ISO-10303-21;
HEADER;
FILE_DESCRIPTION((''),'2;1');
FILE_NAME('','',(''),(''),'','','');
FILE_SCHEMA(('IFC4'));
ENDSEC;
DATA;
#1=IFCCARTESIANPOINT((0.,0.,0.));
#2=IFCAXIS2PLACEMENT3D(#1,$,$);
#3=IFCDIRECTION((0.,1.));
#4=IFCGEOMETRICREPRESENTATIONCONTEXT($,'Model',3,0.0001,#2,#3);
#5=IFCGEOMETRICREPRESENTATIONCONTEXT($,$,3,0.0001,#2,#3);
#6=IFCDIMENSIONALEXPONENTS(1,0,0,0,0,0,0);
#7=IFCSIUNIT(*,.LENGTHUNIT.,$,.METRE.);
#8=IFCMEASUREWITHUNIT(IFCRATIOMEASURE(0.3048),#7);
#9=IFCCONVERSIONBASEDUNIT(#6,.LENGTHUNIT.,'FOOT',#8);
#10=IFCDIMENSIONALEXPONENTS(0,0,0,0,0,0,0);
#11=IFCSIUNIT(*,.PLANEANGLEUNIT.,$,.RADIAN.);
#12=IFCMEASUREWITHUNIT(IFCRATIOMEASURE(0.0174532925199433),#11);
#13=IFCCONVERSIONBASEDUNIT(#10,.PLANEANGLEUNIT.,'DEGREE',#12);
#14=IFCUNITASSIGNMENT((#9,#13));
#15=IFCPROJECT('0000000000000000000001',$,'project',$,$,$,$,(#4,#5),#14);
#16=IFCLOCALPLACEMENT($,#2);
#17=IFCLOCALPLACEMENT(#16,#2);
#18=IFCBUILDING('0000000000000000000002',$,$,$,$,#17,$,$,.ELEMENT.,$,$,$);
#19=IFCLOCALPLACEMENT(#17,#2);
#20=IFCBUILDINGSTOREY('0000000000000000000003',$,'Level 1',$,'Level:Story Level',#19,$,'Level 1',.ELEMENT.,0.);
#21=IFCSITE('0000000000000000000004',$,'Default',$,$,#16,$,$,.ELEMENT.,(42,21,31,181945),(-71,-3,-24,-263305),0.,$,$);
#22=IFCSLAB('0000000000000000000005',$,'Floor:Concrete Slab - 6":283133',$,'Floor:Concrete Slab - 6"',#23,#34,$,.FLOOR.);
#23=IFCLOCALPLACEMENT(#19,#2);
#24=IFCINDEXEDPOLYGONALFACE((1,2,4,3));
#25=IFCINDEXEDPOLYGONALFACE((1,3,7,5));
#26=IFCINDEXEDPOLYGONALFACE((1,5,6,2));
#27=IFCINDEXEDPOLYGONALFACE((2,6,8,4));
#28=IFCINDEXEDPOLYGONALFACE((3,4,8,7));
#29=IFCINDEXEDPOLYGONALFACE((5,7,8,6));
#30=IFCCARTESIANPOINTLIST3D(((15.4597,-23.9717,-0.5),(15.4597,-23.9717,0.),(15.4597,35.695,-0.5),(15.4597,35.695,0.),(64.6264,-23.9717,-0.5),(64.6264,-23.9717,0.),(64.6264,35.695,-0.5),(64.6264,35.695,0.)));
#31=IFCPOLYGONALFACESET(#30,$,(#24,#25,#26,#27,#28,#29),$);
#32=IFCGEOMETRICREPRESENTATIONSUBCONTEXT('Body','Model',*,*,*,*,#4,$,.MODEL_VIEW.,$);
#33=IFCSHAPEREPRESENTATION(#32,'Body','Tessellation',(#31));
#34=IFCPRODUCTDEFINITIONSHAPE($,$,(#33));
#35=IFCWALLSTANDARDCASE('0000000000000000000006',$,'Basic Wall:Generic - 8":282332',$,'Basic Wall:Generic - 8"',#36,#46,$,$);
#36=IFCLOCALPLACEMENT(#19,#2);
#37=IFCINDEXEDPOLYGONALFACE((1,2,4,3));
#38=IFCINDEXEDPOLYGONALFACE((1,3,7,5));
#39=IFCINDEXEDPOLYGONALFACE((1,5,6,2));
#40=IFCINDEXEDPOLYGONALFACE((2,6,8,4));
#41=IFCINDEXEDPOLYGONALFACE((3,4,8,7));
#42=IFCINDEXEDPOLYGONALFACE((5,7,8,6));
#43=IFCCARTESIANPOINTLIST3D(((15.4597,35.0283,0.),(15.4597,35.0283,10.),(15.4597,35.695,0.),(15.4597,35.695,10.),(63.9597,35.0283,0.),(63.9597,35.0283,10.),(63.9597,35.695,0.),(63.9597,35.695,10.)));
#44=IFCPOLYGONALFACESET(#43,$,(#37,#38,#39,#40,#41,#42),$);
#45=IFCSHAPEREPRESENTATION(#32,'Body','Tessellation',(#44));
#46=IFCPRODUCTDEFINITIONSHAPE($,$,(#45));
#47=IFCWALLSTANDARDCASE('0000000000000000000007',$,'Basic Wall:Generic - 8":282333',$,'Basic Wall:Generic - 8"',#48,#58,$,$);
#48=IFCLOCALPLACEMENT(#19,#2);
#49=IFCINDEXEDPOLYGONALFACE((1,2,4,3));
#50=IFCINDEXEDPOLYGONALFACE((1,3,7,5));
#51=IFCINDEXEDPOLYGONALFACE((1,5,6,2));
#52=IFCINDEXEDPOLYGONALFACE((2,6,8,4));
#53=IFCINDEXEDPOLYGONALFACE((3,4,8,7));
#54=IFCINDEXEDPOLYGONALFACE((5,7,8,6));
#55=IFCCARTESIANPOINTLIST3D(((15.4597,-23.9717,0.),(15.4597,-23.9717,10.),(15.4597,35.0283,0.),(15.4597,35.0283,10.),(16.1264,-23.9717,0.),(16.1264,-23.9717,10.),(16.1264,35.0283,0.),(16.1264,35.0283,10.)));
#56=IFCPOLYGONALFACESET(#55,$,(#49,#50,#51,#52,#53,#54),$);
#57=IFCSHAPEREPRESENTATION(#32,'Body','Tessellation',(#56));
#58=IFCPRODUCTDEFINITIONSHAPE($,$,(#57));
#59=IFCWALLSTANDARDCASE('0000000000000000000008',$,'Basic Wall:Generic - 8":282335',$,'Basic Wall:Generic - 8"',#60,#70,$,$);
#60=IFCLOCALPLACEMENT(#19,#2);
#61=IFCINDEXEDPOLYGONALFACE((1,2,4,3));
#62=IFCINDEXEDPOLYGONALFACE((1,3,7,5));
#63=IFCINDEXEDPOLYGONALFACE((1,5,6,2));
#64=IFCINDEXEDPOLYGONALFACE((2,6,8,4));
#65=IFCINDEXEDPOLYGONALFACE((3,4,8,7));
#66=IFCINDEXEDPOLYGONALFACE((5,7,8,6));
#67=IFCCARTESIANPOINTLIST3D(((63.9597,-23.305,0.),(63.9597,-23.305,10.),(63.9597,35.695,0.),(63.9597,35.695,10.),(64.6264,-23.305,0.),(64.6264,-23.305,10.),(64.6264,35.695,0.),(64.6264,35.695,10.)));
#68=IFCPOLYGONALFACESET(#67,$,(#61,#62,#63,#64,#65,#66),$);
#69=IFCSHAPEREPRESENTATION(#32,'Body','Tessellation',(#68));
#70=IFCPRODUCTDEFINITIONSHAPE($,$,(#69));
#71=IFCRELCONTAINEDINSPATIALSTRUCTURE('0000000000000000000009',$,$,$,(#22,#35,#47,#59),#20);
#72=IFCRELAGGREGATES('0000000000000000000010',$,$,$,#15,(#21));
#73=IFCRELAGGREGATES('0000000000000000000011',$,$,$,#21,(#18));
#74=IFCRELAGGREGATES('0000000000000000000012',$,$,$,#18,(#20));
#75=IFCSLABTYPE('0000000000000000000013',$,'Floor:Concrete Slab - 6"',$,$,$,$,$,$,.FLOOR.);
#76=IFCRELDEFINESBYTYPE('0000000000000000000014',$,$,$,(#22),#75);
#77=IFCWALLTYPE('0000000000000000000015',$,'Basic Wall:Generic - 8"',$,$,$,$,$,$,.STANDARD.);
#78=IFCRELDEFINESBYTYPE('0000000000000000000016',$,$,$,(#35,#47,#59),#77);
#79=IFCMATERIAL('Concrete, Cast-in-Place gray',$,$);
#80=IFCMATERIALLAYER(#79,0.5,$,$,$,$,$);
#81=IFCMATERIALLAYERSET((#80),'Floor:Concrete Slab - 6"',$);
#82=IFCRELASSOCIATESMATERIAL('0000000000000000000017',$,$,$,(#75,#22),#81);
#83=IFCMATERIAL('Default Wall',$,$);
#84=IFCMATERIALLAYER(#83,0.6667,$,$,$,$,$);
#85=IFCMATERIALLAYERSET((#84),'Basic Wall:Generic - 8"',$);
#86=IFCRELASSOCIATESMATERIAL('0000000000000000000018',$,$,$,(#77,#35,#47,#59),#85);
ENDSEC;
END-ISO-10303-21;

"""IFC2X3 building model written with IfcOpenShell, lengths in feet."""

from ifc_helpers import new_model, entity, si_unit, converted_unit, direction, frame, frame_2d, origin, place, context, subcontext, project, spatial, rectangle, extrude, material, layer, layer_set, layer_usage, type_object, element, save


model = new_model("IFC2X3")

# Units and contexts
model_context = context("Model", 3, precision=0.0001, world=origin(), true_north=direction((0.0, 1.0)))
context_of_model = context(None, 3, precision=0.0001, world=origin(), true_north=direction((0.0, 1.0)))
body_context = subcontext(model_context, "Body", "Model", "MODEL_VIEW")
ifc_project = project(units=[converted_unit("LENGTHUNIT", "FOOT", entity("IfcRatioMeasure", 0.3048), si_unit("LENGTHUNIT", "METRE"), dimensions=[1, 0, 0, 0, 0, 0, 0]), converted_unit("PLANEANGLEUNIT", "DEGREE", entity("IfcRatioMeasure", 0.0174532925199433), si_unit("PLANEANGLEUNIT", "RADIAN"), dimensions=[0, 0, 0, 0, 0, 0, 0])], contexts=[model_context, context_of_model])

# Site, building, storey
site_placement = place(None, origin())
site = spatial("IfcSite", under=ifc_project, at=site_placement, Name="Default", CompositionType="ELEMENT", RefLatitude=(42, 21, 31, 181945), RefLongitude=(-71, -3, -24, -263305), RefElevation=0.0)
building_placement = place(site_placement, origin())
building = spatial("IfcBuilding", under=site, at=building_placement, CompositionType="ELEMENT")
storey_placement = place(building_placement, origin())
storey = spatial("IfcBuildingStorey", under=building, at=storey_placement, Name="Level 1", ObjectType="Level:Story Level", LongName="Level 1", CompositionType="ELEMENT", Elevation=0.0)

# Slab
ifc_material_1 = material(Name="Concrete, Cast-in-Place gray")
ifc_layer_1 = layer(ifc_material_1, 0.5)
ifc_layer_set_1 = layer_set([ifc_layer_1], Name="Floor:Concrete Slab - 6\"")
ifc_layer_usage_1 = layer_usage(ifc_layer_set_1, "AXIS3", "POSITIVE", 0.0)
slab_type = type_object("IfcSlabType", Name="Floor:Concrete Slab - 6\"", PredefinedType="FLOOR", material=ifc_layer_set_1)
slab_placement = place(storey_placement, origin())
element("IfcSlab", 1, at=slab_placement, inside=storey, type_object=slab_type, material=ifc_layer_usage_1, Name="Floor:Concrete Slab - 6\":283133", ObjectType="Floor:Concrete Slab - 6\"", PredefinedType="FLOOR", context=body_context, shape_type="SweptSolid", body=[
    extrude(rectangle(XDim=59.6667, YDim=49.1667, at=frame_2d((0.0, 0.0), x_axis=(1.0, 0.0))), frame((40.0431, 5.8617, 0.0), z_axis=(0.0, 0.0, -1.0), x_axis=(0.0, 1.0, 0.0)), (0.0, 0.0, 1.0), 0.5),
])

# Walls
ifc_material_2 = material(Name="Default Wall")
ifc_layer_2 = layer(ifc_material_2, 0.6667)
ifc_layer_set_2 = layer_set([ifc_layer_2], Name="Basic Wall:Generic - 8\"")
ifc_layer_usage_2 = layer_usage(ifc_layer_set_2, "AXIS2", "NEGATIVE", 0.3333)
wall_type = type_object("IfcWallType", Name="Basic Wall:Generic - 8\"", PredefinedType="STANDARD", material=ifc_layer_set_2)
wall_1_placement = place(storey_placement, frame((15.4597, 35.3617, 0.0)))
element("IfcWallStandardCase", 2, at=wall_1_placement, inside=storey, type_object=wall_type, material=ifc_layer_usage_2, Name="Basic Wall:Generic - 8\":282332", ObjectType="Basic Wall:Generic - 8\"", context=body_context, shape_type="SweptSolid", body=[
    extrude(rectangle(XDim=48.5, YDim=0.6667, at=frame_2d((24.25, 0.0), x_axis=(-1.0, 0.0))), origin(), (0.0, 0.0, 1.0), 10.0),
])
ifc_layer_usage_3 = layer_usage(ifc_layer_set_2, "AXIS2", "NEGATIVE", 0.3333)
wall_2_placement = place(storey_placement, frame((15.7931, -23.9717, 0.0), z_axis=(0.0, 0.0, 1.0), x_axis=(0.0, 1.0, 0.0)))
element("IfcWallStandardCase", 3, at=wall_2_placement, inside=storey, type_object=wall_type, material=ifc_layer_usage_3, Name="Basic Wall:Generic - 8\":282333", ObjectType="Basic Wall:Generic - 8\"", context=body_context, shape_type="SweptSolid", body=[
    extrude(rectangle(XDim=59.0, YDim=0.6667, at=frame_2d((29.5, 0.0), x_axis=(-1.0, 0.0))), origin(), (0.0, 0.0, 1.0), 10.0),
])

# Wall
ifc_layer_usage_4 = layer_usage(ifc_layer_set_2, "AXIS2", "NEGATIVE", 0.3333)
wall_3_placement = place(storey_placement, frame((64.2931, 35.695, 0.0), z_axis=(0.0, 0.0, 1.0), x_axis=(0.0, -1.0, 0.0)))
element("IfcWallStandardCase", 4, at=wall_3_placement, inside=storey, type_object=wall_type, material=ifc_layer_usage_4, Name="Basic Wall:Generic - 8\":282335", ObjectType="Basic Wall:Generic - 8\"", context=body_context, shape_type="SweptSolid", body=[
    extrude(rectangle(XDim=59.0, YDim=0.6667, at=frame_2d((29.5, 0.0), x_axis=(-1.0, 0.0))), origin(), (0.0, 0.0, 1.0), 10.0),
])

save(model, "model.ifc")
